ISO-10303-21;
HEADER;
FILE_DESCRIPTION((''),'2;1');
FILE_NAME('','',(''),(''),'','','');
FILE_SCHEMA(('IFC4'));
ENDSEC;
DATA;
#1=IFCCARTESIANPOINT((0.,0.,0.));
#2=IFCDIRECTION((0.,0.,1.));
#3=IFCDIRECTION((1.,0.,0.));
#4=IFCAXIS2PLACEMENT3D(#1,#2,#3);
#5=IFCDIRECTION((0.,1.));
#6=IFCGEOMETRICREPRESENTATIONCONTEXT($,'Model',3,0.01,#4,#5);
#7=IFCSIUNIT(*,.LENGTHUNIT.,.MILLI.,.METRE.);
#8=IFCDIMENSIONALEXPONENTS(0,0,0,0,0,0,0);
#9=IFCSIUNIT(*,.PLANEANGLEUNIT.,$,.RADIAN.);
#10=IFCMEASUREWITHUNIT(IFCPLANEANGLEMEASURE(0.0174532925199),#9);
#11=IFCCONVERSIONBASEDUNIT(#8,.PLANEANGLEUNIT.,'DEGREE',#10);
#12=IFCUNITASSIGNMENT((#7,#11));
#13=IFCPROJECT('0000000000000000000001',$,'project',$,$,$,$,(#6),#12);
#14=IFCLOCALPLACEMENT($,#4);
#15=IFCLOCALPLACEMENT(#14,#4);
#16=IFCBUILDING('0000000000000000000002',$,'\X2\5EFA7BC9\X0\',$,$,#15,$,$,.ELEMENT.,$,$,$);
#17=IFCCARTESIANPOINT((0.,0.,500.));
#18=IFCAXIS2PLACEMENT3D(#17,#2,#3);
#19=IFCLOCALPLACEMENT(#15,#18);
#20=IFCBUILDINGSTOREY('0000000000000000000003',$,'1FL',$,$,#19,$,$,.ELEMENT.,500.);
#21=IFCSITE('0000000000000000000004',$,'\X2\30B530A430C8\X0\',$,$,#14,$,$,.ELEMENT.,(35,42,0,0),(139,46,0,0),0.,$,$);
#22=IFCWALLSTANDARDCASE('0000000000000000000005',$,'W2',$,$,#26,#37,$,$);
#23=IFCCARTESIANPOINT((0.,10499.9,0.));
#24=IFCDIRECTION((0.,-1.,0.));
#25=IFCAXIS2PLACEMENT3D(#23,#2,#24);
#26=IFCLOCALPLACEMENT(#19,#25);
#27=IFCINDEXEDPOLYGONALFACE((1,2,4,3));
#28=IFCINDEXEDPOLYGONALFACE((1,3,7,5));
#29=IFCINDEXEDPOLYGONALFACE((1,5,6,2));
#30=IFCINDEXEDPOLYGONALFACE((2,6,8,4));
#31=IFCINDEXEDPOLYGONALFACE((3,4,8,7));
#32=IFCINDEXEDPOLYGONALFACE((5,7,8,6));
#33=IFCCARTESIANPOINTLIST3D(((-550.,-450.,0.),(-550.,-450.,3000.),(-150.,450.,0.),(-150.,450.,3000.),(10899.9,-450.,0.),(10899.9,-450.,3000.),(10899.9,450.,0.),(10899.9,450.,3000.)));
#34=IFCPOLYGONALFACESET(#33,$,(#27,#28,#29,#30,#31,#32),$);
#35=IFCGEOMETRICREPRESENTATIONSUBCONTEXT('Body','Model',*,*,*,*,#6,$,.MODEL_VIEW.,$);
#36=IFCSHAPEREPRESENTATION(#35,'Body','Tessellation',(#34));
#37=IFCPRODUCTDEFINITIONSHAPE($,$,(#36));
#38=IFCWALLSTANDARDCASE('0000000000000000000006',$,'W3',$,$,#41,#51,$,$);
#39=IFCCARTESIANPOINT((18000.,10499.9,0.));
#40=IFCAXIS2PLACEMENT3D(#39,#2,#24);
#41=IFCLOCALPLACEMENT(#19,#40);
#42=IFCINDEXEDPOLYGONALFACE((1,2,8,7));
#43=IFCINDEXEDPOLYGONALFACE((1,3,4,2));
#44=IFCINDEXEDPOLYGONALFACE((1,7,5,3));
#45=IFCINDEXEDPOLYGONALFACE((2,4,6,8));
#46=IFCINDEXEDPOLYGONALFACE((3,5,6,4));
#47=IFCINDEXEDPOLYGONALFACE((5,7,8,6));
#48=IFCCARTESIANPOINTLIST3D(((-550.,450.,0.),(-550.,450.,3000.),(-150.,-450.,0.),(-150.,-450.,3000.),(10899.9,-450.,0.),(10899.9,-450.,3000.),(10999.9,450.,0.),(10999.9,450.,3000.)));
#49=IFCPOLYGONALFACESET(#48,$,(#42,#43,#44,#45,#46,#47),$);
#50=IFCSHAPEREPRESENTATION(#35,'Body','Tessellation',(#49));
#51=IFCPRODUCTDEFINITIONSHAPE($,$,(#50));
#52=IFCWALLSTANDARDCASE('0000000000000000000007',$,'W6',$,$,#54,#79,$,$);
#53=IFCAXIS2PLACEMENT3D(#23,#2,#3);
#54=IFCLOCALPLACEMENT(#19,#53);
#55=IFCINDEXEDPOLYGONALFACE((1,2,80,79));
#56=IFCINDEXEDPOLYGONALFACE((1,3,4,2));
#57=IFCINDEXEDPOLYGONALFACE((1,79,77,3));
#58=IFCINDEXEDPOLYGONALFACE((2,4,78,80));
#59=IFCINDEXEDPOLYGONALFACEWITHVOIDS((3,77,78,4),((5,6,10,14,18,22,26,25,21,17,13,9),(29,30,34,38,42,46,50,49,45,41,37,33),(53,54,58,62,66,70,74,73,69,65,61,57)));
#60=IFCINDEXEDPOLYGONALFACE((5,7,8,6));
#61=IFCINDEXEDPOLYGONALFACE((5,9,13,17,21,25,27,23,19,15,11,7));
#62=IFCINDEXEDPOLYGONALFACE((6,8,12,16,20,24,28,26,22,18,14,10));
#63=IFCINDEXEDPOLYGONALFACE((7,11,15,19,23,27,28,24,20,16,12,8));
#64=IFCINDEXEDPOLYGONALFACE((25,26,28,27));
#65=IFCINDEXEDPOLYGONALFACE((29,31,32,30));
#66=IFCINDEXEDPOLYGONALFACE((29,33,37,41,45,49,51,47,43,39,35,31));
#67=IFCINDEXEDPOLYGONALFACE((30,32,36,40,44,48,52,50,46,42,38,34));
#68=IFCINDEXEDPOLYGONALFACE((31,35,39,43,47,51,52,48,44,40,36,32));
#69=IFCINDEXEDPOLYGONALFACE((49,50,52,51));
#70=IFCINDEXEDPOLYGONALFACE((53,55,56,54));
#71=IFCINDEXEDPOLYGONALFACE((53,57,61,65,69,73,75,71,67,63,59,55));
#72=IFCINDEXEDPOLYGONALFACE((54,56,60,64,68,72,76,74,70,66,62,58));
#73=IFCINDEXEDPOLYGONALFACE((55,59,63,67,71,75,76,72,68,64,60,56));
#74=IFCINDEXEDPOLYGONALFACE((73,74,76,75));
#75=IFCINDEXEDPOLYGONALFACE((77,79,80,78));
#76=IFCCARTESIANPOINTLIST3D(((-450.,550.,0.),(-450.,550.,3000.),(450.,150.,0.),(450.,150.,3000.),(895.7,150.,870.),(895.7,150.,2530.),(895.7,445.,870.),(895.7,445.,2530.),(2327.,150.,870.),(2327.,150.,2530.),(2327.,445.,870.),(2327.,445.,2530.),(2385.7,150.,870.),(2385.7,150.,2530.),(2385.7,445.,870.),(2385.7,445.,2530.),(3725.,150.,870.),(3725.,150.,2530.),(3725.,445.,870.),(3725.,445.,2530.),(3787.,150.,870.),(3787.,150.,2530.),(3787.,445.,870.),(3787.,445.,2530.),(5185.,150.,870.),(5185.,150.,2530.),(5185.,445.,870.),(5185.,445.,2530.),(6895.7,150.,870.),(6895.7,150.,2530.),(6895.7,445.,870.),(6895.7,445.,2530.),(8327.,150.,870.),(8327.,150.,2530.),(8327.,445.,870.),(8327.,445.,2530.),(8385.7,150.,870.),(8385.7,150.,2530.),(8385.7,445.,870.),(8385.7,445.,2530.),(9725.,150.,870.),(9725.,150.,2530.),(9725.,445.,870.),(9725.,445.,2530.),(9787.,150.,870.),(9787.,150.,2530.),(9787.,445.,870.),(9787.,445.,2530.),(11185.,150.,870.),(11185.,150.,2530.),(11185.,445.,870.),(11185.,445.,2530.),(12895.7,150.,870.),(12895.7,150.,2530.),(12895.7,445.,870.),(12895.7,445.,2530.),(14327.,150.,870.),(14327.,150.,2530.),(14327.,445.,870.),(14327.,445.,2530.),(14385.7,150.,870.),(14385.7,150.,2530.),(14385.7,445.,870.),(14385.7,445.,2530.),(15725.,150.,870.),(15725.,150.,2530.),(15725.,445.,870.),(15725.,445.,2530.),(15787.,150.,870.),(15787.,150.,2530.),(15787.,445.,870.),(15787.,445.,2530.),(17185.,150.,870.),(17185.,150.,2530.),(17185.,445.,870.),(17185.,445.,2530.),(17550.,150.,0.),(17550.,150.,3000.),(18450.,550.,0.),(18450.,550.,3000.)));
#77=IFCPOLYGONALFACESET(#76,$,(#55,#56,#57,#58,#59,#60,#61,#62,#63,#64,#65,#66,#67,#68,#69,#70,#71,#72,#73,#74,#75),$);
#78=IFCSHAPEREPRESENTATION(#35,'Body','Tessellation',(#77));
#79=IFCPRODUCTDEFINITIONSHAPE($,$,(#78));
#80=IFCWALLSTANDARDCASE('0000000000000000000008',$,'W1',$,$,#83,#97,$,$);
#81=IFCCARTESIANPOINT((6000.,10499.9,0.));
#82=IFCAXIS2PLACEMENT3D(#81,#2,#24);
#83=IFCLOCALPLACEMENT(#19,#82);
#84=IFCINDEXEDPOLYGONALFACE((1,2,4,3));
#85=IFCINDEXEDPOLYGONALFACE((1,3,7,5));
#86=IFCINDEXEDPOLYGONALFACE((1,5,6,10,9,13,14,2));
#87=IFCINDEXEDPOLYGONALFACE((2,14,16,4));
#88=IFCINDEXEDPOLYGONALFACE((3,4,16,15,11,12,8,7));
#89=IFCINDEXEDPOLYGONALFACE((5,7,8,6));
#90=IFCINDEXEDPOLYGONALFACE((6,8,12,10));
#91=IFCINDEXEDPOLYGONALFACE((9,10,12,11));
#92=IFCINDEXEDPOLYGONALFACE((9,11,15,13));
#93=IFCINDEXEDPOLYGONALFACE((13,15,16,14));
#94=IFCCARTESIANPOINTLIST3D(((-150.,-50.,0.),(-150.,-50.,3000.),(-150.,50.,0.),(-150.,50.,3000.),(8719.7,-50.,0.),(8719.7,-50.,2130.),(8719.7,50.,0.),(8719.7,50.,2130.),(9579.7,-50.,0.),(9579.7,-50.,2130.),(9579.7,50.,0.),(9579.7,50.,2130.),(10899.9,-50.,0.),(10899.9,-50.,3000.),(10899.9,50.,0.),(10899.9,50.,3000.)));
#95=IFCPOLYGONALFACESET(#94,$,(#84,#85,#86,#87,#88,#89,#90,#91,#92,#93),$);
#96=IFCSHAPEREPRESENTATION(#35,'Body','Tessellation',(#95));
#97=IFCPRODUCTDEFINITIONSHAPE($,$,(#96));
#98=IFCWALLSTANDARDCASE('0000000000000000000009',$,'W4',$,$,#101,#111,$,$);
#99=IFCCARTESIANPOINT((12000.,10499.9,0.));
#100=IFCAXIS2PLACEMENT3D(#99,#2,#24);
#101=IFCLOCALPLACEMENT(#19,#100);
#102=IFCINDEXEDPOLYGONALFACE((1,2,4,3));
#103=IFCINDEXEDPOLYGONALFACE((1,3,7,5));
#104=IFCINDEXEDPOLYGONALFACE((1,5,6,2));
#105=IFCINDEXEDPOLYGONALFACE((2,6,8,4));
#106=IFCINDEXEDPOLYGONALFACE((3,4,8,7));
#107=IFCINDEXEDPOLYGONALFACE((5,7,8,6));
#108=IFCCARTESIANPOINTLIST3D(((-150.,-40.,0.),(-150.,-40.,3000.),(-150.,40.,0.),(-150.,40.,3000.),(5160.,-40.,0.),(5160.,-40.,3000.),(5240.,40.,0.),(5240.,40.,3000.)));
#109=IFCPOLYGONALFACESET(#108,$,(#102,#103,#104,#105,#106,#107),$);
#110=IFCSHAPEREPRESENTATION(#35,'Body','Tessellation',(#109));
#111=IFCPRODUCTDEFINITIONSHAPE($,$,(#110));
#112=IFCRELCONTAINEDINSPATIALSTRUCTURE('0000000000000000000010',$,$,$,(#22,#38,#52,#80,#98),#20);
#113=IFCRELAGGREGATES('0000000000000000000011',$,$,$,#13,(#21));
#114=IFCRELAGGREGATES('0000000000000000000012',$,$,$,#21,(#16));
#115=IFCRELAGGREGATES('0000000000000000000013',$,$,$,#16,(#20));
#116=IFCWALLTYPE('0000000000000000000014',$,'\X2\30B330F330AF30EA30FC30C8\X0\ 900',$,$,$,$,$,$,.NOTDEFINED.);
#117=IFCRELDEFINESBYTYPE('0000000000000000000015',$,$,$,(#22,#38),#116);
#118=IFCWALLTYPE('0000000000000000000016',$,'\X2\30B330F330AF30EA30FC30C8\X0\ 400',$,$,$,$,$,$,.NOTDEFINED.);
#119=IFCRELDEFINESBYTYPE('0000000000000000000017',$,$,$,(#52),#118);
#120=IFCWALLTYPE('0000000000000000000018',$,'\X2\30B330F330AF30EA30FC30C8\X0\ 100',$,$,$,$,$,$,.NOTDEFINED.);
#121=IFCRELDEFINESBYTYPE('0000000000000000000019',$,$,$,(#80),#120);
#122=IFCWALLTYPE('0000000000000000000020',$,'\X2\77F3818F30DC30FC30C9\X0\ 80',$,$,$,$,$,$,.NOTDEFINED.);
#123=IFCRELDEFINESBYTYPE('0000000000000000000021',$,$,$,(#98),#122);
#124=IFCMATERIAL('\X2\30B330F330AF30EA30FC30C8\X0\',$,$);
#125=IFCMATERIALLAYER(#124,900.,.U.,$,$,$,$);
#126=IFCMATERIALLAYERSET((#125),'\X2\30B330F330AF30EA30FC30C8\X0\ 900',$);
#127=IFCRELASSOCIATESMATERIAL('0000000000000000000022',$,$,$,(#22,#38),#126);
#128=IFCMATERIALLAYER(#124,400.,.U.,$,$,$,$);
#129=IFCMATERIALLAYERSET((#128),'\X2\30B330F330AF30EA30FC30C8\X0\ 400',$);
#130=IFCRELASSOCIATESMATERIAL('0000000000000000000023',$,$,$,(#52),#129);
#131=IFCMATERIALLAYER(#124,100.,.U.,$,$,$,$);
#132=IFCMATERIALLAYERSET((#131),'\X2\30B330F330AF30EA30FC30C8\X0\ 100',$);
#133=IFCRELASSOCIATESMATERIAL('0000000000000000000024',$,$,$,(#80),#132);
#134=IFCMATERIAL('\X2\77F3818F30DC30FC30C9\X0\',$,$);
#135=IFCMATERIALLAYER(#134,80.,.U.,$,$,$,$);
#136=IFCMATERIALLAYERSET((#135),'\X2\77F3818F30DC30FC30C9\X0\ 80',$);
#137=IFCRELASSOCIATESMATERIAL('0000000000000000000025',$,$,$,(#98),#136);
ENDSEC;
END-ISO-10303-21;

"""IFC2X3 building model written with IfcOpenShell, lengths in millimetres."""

from ifc_helpers import new_model, entity, si_unit, converted_unit, direction, frame, origin_with_axes, origin_2d_with_axis, place, context, subcontext, project, spatial, polyline, rectangle, outline, extrude, material, layer, layer_set, layer_usage, type_object, element, save


model = new_model("IFC2X3")

# Units and contexts
model_context = context("Model", 3, precision=0.01, world=origin_with_axes(), true_north=direction((0.0, 1.0)))
body_context = subcontext(model_context, "Body", "Model", "MODEL_VIEW")
ifc_project = project(units=[si_unit("LENGTHUNIT", "METRE", prefix="MILLI"), converted_unit("PLANEANGLEUNIT", "DEGREE", entity("IfcPlaneAngleMeasure", 0.0174532925199), si_unit("PLANEANGLEUNIT", "RADIAN"), dimensions=[0, 0, 0, 0, 0, 0, 0])], contexts=[model_context])

# Site, building, storey
site_placement = place(None, origin_with_axes())
site = spatial("IfcSite", under=ifc_project, at=site_placement, Name="サイト", CompositionType="ELEMENT", RefLatitude=(35, 42, 0, 0), RefLongitude=(139, 46, 0, 0), RefElevation=0.0)
building_placement = place(site_placement, origin_with_axes())
building = spatial("IfcBuilding", under=site, at=building_placement, Name="建築", CompositionType="ELEMENT")
storey_placement = place(building_placement, frame((0.0, 0.0, 500.0), z_axis=(0.0, 0.0, 1.0), x_axis=(1.0, 0.0, 0.0)))
storey = spatial("IfcBuildingStorey", under=building, at=storey_placement, Name="1FL", CompositionType="ELEMENT", Elevation=500.0)

# Shared definitions
ifc_material_1 = material(Name="コンクリート")

# Walls
ifc_layer_1 = layer(ifc_material_1, 900.0, ventilated="UNKNOWN")
ifc_layer_set_1 = layer_set([ifc_layer_1], Name="コンクリート 900")
wall_type_1 = type_object("IfcWallType", Name="コンクリート 900", PredefinedType="NOTDEFINED")
ifc_layer_usage_1 = layer_usage(ifc_layer_set_1, "AXIS2", "POSITIVE", -450.0)
wall_1_placement = place(storey_placement, frame((0.0, 10499.9, 0.0), z_axis=(0.0, 0.0, 1.0), x_axis=(0.0, -1.0, 0.0)))
element("IfcWallStandardCase", 1, at=wall_1_placement, inside=storey, type_object=wall_type_1, material=ifc_layer_usage_1, Name="W2", context=body_context, shape_type="SweptSolid", body=[
    extrude(outline(polyline([(-550.0, -450.0), (10899.9, -450.0), (10899.9, 450.0), (-150.0, 450.0), (-550.0, -450.0)])), origin_with_axes(), (0.0, 0.0, 1.0), 3000.0),
])
ifc_layer_usage_2 = layer_usage(ifc_layer_set_1, "AXIS2", "POSITIVE", -450.0)
wall_2_placement = place(storey_placement, frame((18000.0, 10499.9, 0.0), z_axis=(0.0, 0.0, 1.0), x_axis=(0.0, -1.0, 0.0)))
element("IfcWallStandardCase", 2, at=wall_2_placement, inside=storey, type_object=wall_type_1, material=ifc_layer_usage_2, Name="W3", context=body_context, shape_type="SweptSolid", body=[
    extrude(outline(polyline([(-150.0, -450.0), (10899.9, -450.0), (10999.9, 450.0), (-550.0, 450.0), (-150.0, -450.0)])), origin_with_axes(), (0.0, 0.0, 1.0), 3000.0),
])

# Wall, openings
ifc_layer_2 = layer(ifc_material_1, 400.0, ventilated="UNKNOWN")
ifc_layer_set_2 = layer_set([ifc_layer_2], Name="コンクリート 400")
ifc_layer_usage_3 = layer_usage(ifc_layer_set_2, "AXIS2", "POSITIVE", 150.0)
wall_type_2 = type_object("IfcWallType", Name="コンクリート 400", PredefinedType="NOTDEFINED")
wall_3_placement = place(storey_placement, frame((0.0, 10499.9, 0.0), z_axis=(0.0, 0.0, 1.0), x_axis=(1.0, 0.0, 0.0)))
wall_3 = element("IfcWallStandardCase", 3, at=wall_3_placement, inside=storey, type_object=wall_type_2, material=ifc_layer_usage_3, Name="W6", context=body_context, shape_type="SweptSolid", body=[
    extrude(outline(polyline([(450.0, 150.0), (17550.0, 150.0), (18450.0, 550.0), (-450.0, 550.0), (450.0, 150.0)])), origin_with_axes(), (0.0, 0.0, 1.0), 3000.0),
])
opening_1_placement = place(wall_3_placement, frame((1640.7, 0.0, 900.0), z_axis=(0.0, 0.0, 1.0), x_axis=(1.0, 0.0, 0.0)))
element("IfcOpeningElement", 4, at=opening_1_placement, cuts=wall_3, ObjectType="Recess", context=body_context, shape_type="SweptSolid", body=[
    extrude(rectangle(XDim=1490.0, YDim=1660.0, at=origin_2d_with_axis()), frame((0.0, -445.0, 800.0), z_axis=(0.0, 1.0, 0.0), x_axis=(-1.0, 0.0, 0.0)), (0.0, 0.0, 1.0), 890.0),
])
opening_2_placement = place(wall_3_placement, frame((3057.0, 0.0, 900.0), z_axis=(0.0, 0.0, 1.0), x_axis=(1.0, 0.0, 0.0)))
element("IfcOpeningElement", 5, at=opening_2_placement, cuts=wall_3, ObjectType="Recess", context=body_context, shape_type="SweptSolid", body=[
    extrude(rectangle(XDim=1460.0, YDim=1660.0, at=origin_2d_with_axis()), frame((0.0, -445.0, 800.0), z_axis=(0.0, 1.0, 0.0), x_axis=(-1.0, 0.0, 0.0)), (0.0, 0.0, 1.0), 890.0),
])
opening_3_placement = place(wall_3_placement, frame((4455.0, 0.0, 900.0), z_axis=(0.0, 0.0, 1.0), x_axis=(1.0, 0.0, 0.0)))
element("IfcOpeningElement", 6, at=opening_3_placement, cuts=wall_3, ObjectType="Recess", context=body_context, shape_type="SweptSolid", body=[
    extrude(rectangle(XDim=1460.0, YDim=1660.0, at=origin_2d_with_axis()), frame((0.0, -445.0, 800.0), z_axis=(0.0, 1.0, 0.0), x_axis=(-1.0, 0.0, 0.0)), (0.0, 0.0, 1.0), 890.0),
])
opening_4_placement = place(wall_3_placement, frame((7640.7, 0.0, 900.0), z_axis=(0.0, 0.0, 1.0), x_axis=(1.0, 0.0, 0.0)))
element("IfcOpeningElement", 7, at=opening_4_placement, cuts=wall_3, ObjectType="Recess", context=body_context, shape_type="SweptSolid", body=[
    extrude(rectangle(XDim=1490.0, YDim=1660.0, at=origin_2d_with_axis()), frame((0.0, -445.0, 800.0), z_axis=(0.0, 1.0, 0.0), x_axis=(-1.0, 0.0, 0.0)), (0.0, 0.0, 1.0), 890.0),
])
opening_5_placement = place(wall_3_placement, frame((9057.0, 0.0, 900.0), z_axis=(0.0, 0.0, 1.0), x_axis=(1.0, 0.0, 0.0)))
element("IfcOpeningElement", 8, at=opening_5_placement, cuts=wall_3, ObjectType="Recess", context=body_context, shape_type="SweptSolid", body=[
    extrude(rectangle(XDim=1460.0, YDim=1660.0, at=origin_2d_with_axis()), frame((0.0, -445.0, 800.0), z_axis=(0.0, 1.0, 0.0), x_axis=(-1.0, 0.0, 0.0)), (0.0, 0.0, 1.0), 890.0),
])
opening_6_placement = place(wall_3_placement, frame((10455.0, 0.0, 900.0), z_axis=(0.0, 0.0, 1.0), x_axis=(1.0, 0.0, 0.0)))
element("IfcOpeningElement", 9, at=opening_6_placement, cuts=wall_3, ObjectType="Recess", context=body_context, shape_type="SweptSolid", body=[
    extrude(rectangle(XDim=1460.0, YDim=1660.0, at=origin_2d_with_axis()), frame((0.0, -445.0, 800.0), z_axis=(0.0, 1.0, 0.0), x_axis=(-1.0, 0.0, 0.0)), (0.0, 0.0, 1.0), 890.0),
])
opening_7_placement = place(wall_3_placement, frame((13640.7, 0.0, 900.0), z_axis=(0.0, 0.0, 1.0), x_axis=(1.0, 0.0, 0.0)))
element("IfcOpeningElement", 10, at=opening_7_placement, cuts=wall_3, ObjectType="Recess", context=body_context, shape_type="SweptSolid", body=[
    extrude(rectangle(XDim=1490.0, YDim=1660.0, at=origin_2d_with_axis()), frame((0.0, -445.0, 800.0), z_axis=(0.0, 1.0, 0.0), x_axis=(-1.0, 0.0, 0.0)), (0.0, 0.0, 1.0), 890.0),
])
opening_8_placement = place(wall_3_placement, frame((15057.0, 0.0, 900.0), z_axis=(0.0, 0.0, 1.0), x_axis=(1.0, 0.0, 0.0)))
element("IfcOpeningElement", 11, at=opening_8_placement, cuts=wall_3, ObjectType="Recess", context=body_context, shape_type="SweptSolid", body=[
    extrude(rectangle(XDim=1460.0, YDim=1660.0, at=origin_2d_with_axis()), frame((0.0, -445.0, 800.0), z_axis=(0.0, 1.0, 0.0), x_axis=(-1.0, 0.0, 0.0)), (0.0, 0.0, 1.0), 890.0),
])
opening_9_placement = place(wall_3_placement, frame((16455.0, 0.0, 900.0), z_axis=(0.0, 0.0, 1.0), x_axis=(1.0, 0.0, 0.0)))
element("IfcOpeningElement", 12, at=opening_9_placement, cuts=wall_3, ObjectType="Recess", context=body_context, shape_type="SweptSolid", body=[
    extrude(rectangle(XDim=1460.0, YDim=1660.0, at=origin_2d_with_axis()), frame((0.0, -445.0, 800.0), z_axis=(0.0, 1.0, 0.0), x_axis=(-1.0, 0.0, 0.0)), (0.0, 0.0, 1.0), 890.0),
])
ifc_material_2 = material(Name="石膏ボード")

# Wall, opening
ifc_layer_3 = layer(ifc_material_1, 100.0, ventilated="UNKNOWN")
ifc_layer_set_3 = layer_set([ifc_layer_3], Name="コンクリート 100")
ifc_layer_usage_4 = layer_usage(ifc_layer_set_3, "AXIS2", "POSITIVE", -50.0)
wall_type_3 = type_object("IfcWallType", Name="コンクリート 100", PredefinedType="NOTDEFINED")
wall_4_placement = place(storey_placement, frame((6000.0, 10499.9, 0.0), z_axis=(0.0, 0.0, 1.0), x_axis=(0.0, -1.0, 0.0)))
wall_4 = element("IfcWallStandardCase", 13, at=wall_4_placement, inside=storey, type_object=wall_type_3, material=ifc_layer_usage_4, Name="W1", context=body_context, shape_type="SweptSolid", body=[
    extrude(outline(polyline([(-150.0, -50.0), (10899.9, -50.0), (10899.9, 50.0), (-150.0, 50.0), (-150.0, -50.0)])), origin_with_axes(), (0.0, 0.0, 1.0), 3000.0),
])
opening_10_placement = place(wall_4_placement, frame((9149.7, 0.0, 0.0), z_axis=(0.0, 0.0, 1.0), x_axis=(1.0, 0.0, 0.0)))
element("IfcOpeningElement", 14, at=opening_10_placement, cuts=wall_4, context=body_context, shape_type="SweptSolid", body=[
    extrude(outline(polyline([(-430.0, 0.0), (-430.0, -2130.0), (430.0, -2130.0), (430.0, 0.0), (-430.0, 0.0)])), frame((0.0, 110.0, 0.0), z_axis=(0.0, 1.0, 0.0), x_axis=(1.0, 0.0, 0.0)), (0.0, 0.0, -1.0), 220.0),
])

# Wall
ifc_layer_4 = layer(ifc_material_2, 80.0, ventilated="UNKNOWN")
ifc_layer_set_4 = layer_set([ifc_layer_4], Name="石膏ボード 80")
ifc_layer_usage_5 = layer_usage(ifc_layer_set_4, "AXIS2", "POSITIVE", -40.0)
wall_type_4 = type_object("IfcWallType", Name="石膏ボード 80", PredefinedType="NOTDEFINED")
wall_5_placement = place(storey_placement, frame((12000.0, 10499.9, 0.0), z_axis=(0.0, 0.0, 1.0), x_axis=(0.0, -1.0, 0.0)))
element("IfcWallStandardCase", 15, at=wall_5_placement, inside=storey, type_object=wall_type_4, material=ifc_layer_usage_5, Name="W4", context=body_context, shape_type="SweptSolid", body=[
    extrude(outline(polyline([(-150.0, -40.0), (5160.0, -40.0), (5240.0, 40.0), (-150.0, 40.0), (-150.0, -40.0)])), origin_with_axes(), (0.0, 0.0, 1.0), 3000.0),
])

save(model, "model.ifc")
